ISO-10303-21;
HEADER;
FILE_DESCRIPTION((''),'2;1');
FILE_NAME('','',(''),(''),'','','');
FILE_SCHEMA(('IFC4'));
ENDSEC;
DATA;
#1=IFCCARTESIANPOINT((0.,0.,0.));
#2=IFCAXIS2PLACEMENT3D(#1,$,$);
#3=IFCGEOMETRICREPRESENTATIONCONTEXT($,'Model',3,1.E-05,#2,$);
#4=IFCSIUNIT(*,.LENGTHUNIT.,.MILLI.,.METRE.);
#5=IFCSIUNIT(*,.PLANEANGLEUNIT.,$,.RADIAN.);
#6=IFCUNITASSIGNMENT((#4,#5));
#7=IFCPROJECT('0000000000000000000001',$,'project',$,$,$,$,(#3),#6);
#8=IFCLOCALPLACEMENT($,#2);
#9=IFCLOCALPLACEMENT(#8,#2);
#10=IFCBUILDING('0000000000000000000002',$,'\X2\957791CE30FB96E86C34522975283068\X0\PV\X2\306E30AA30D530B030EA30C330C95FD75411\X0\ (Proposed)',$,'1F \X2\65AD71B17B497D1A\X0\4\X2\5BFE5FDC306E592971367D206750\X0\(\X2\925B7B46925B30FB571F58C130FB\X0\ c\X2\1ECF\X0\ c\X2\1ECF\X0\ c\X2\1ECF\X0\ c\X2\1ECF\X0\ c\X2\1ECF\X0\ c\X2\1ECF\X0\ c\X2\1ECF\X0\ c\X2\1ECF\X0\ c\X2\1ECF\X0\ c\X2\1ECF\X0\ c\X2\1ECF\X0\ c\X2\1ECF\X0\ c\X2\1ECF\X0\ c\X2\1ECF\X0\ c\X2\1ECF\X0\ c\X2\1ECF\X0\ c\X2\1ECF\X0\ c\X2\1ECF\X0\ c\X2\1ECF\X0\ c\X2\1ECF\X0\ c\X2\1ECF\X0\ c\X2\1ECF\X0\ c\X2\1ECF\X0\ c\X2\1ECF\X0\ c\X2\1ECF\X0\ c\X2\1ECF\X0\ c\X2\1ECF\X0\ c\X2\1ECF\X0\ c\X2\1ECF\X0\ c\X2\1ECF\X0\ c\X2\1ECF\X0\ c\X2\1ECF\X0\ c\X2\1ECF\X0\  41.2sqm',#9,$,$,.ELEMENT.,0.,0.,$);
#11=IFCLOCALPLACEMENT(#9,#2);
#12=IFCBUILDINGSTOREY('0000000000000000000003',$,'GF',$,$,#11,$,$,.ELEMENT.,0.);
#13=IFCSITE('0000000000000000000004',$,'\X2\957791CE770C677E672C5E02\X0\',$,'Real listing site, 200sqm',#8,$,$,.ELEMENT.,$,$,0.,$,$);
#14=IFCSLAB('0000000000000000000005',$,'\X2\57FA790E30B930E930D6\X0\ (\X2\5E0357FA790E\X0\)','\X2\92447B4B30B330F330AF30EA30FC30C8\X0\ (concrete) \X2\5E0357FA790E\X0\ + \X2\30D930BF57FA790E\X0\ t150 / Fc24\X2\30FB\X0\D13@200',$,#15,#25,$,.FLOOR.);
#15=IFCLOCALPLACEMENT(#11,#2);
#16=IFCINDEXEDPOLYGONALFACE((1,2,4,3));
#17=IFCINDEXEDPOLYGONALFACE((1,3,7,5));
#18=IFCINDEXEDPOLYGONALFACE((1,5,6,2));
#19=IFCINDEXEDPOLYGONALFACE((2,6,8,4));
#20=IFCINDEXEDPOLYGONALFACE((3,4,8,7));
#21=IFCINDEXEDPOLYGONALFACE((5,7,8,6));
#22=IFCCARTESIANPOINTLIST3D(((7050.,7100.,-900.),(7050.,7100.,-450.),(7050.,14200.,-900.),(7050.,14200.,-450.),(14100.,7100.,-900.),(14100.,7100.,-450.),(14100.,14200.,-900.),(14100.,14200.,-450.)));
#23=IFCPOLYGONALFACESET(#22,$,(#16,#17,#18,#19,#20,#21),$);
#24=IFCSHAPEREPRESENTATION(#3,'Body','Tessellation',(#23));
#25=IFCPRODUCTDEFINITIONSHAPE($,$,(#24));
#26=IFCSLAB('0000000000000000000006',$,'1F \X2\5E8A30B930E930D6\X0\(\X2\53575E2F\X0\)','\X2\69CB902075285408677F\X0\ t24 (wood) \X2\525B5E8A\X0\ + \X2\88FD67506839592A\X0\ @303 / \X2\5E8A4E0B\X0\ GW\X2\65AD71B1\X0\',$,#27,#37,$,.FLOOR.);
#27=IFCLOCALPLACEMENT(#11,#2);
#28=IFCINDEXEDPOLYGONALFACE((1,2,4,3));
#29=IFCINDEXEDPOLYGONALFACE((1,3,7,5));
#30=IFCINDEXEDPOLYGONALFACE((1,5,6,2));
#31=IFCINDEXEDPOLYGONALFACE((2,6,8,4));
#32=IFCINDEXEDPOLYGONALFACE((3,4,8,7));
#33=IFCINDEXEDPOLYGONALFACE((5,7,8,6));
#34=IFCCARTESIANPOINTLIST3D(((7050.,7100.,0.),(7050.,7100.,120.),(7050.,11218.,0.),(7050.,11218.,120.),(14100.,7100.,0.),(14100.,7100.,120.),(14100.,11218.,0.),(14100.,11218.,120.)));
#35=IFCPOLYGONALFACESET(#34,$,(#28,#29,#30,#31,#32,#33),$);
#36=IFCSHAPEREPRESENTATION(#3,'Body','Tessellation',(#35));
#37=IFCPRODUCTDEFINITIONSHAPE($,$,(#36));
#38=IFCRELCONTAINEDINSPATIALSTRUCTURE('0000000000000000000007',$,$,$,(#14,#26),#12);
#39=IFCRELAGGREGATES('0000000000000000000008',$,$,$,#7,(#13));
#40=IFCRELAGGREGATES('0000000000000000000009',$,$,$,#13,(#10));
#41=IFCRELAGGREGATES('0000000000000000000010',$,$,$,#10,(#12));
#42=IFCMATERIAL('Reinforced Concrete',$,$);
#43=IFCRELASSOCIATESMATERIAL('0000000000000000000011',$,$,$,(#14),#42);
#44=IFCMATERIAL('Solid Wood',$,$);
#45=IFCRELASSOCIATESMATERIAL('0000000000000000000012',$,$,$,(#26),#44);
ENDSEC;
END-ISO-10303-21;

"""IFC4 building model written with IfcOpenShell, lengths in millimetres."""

from ifc_helpers import new_model, si_unit, frame, frame_2d, origin, place, context, project, spatial, rectangle, extrude, material, element, save


model = new_model("IFC4")

# Units and contexts
model_context = context("Model", 3, precision=1e-05, world=origin())
ifc_project = project(units=[si_unit("LENGTHUNIT", "METRE", prefix="MILLI"), si_unit("PLANEANGLEUNIT", "RADIAN")], contexts=[model_context])

# Site, building, storey
site_placement = place(None, origin())
site = spatial("IfcSite", under=ifc_project, at=site_placement, Name="長野県松本市", ObjectType="Real listing site, 200sqm", CompositionType="ELEMENT", RefElevation=0.0)
building_placement = place(site_placement, origin())
building = spatial("IfcBuilding", under=site, at=building_placement, Name="長野・雨水利用とPVのオフグリッド志向 (Proposed)", ObjectType="1F 断熱等級4対応の天然素材(鉛筆鉛・土壁・ cỏ cỏ cỏ cỏ cỏ cỏ cỏ cỏ cỏ cỏ cỏ cỏ cỏ cỏ cỏ cỏ cỏ cỏ cỏ cỏ cỏ cỏ cỏ cỏ cỏ cỏ cỏ cỏ cỏ cỏ cỏ cỏ cỏ  41.2sqm", CompositionType="ELEMENT", ElevationOfRefHeight=0.0, ElevationOfTerrain=0.0)
storey_placement = place(building_placement, origin())
storey = spatial("IfcBuildingStorey", under=building, at=storey_placement, Name="GF", CompositionType="ELEMENT", Elevation=0.0)

# Shared definitions
ifc_material_1 = material(Name="Solid Wood")

# Slabs
ifc_material_2 = material(Name="Reinforced Concrete")
slab_1_placement = place(storey_placement, frame((3525.0, 3550.0, -450.0)))
element("IfcSlab", 1, at=slab_1_placement, inside=storey, material=ifc_material_2, Name="基礎スラブ (布基礎)", Description="鉄筋コンクリート (concrete) 布基礎 + ベタ基礎 t150 / Fc24・D13@200", PredefinedType="FLOOR", context=model_context, shape_type="SweptSolid", body=[
    extrude(rectangle(XDim=7050.0, YDim=7100.0, at=frame_2d((3525.0, 3550.0))), frame((3525.0, 3550.0, -450.0)), (0.0, 0.0, 1.0), 450.0),
])
slab_2_placement = place(storey_placement, frame((3525.0, 3550.0, 0.0)))
element("IfcSlab", 2, at=slab_2_placement, inside=storey, material=ifc_material_1, Name="1F 床スラブ(南帯)", Description="構造用合板 t24 (wood) 剛床 + 製材根太 @303 / 床下 GW断熱", PredefinedType="FLOOR", context=model_context, shape_type="SweptSolid", body=[
    extrude(rectangle(XDim=7050.0, YDim=4118.0, at=frame_2d((3525.0, 2059.0))), frame((3525.0, 3550.0, 0.0)), (0.0, 0.0, 1.0), 120.0),
])

save(model, "model.ifc")
